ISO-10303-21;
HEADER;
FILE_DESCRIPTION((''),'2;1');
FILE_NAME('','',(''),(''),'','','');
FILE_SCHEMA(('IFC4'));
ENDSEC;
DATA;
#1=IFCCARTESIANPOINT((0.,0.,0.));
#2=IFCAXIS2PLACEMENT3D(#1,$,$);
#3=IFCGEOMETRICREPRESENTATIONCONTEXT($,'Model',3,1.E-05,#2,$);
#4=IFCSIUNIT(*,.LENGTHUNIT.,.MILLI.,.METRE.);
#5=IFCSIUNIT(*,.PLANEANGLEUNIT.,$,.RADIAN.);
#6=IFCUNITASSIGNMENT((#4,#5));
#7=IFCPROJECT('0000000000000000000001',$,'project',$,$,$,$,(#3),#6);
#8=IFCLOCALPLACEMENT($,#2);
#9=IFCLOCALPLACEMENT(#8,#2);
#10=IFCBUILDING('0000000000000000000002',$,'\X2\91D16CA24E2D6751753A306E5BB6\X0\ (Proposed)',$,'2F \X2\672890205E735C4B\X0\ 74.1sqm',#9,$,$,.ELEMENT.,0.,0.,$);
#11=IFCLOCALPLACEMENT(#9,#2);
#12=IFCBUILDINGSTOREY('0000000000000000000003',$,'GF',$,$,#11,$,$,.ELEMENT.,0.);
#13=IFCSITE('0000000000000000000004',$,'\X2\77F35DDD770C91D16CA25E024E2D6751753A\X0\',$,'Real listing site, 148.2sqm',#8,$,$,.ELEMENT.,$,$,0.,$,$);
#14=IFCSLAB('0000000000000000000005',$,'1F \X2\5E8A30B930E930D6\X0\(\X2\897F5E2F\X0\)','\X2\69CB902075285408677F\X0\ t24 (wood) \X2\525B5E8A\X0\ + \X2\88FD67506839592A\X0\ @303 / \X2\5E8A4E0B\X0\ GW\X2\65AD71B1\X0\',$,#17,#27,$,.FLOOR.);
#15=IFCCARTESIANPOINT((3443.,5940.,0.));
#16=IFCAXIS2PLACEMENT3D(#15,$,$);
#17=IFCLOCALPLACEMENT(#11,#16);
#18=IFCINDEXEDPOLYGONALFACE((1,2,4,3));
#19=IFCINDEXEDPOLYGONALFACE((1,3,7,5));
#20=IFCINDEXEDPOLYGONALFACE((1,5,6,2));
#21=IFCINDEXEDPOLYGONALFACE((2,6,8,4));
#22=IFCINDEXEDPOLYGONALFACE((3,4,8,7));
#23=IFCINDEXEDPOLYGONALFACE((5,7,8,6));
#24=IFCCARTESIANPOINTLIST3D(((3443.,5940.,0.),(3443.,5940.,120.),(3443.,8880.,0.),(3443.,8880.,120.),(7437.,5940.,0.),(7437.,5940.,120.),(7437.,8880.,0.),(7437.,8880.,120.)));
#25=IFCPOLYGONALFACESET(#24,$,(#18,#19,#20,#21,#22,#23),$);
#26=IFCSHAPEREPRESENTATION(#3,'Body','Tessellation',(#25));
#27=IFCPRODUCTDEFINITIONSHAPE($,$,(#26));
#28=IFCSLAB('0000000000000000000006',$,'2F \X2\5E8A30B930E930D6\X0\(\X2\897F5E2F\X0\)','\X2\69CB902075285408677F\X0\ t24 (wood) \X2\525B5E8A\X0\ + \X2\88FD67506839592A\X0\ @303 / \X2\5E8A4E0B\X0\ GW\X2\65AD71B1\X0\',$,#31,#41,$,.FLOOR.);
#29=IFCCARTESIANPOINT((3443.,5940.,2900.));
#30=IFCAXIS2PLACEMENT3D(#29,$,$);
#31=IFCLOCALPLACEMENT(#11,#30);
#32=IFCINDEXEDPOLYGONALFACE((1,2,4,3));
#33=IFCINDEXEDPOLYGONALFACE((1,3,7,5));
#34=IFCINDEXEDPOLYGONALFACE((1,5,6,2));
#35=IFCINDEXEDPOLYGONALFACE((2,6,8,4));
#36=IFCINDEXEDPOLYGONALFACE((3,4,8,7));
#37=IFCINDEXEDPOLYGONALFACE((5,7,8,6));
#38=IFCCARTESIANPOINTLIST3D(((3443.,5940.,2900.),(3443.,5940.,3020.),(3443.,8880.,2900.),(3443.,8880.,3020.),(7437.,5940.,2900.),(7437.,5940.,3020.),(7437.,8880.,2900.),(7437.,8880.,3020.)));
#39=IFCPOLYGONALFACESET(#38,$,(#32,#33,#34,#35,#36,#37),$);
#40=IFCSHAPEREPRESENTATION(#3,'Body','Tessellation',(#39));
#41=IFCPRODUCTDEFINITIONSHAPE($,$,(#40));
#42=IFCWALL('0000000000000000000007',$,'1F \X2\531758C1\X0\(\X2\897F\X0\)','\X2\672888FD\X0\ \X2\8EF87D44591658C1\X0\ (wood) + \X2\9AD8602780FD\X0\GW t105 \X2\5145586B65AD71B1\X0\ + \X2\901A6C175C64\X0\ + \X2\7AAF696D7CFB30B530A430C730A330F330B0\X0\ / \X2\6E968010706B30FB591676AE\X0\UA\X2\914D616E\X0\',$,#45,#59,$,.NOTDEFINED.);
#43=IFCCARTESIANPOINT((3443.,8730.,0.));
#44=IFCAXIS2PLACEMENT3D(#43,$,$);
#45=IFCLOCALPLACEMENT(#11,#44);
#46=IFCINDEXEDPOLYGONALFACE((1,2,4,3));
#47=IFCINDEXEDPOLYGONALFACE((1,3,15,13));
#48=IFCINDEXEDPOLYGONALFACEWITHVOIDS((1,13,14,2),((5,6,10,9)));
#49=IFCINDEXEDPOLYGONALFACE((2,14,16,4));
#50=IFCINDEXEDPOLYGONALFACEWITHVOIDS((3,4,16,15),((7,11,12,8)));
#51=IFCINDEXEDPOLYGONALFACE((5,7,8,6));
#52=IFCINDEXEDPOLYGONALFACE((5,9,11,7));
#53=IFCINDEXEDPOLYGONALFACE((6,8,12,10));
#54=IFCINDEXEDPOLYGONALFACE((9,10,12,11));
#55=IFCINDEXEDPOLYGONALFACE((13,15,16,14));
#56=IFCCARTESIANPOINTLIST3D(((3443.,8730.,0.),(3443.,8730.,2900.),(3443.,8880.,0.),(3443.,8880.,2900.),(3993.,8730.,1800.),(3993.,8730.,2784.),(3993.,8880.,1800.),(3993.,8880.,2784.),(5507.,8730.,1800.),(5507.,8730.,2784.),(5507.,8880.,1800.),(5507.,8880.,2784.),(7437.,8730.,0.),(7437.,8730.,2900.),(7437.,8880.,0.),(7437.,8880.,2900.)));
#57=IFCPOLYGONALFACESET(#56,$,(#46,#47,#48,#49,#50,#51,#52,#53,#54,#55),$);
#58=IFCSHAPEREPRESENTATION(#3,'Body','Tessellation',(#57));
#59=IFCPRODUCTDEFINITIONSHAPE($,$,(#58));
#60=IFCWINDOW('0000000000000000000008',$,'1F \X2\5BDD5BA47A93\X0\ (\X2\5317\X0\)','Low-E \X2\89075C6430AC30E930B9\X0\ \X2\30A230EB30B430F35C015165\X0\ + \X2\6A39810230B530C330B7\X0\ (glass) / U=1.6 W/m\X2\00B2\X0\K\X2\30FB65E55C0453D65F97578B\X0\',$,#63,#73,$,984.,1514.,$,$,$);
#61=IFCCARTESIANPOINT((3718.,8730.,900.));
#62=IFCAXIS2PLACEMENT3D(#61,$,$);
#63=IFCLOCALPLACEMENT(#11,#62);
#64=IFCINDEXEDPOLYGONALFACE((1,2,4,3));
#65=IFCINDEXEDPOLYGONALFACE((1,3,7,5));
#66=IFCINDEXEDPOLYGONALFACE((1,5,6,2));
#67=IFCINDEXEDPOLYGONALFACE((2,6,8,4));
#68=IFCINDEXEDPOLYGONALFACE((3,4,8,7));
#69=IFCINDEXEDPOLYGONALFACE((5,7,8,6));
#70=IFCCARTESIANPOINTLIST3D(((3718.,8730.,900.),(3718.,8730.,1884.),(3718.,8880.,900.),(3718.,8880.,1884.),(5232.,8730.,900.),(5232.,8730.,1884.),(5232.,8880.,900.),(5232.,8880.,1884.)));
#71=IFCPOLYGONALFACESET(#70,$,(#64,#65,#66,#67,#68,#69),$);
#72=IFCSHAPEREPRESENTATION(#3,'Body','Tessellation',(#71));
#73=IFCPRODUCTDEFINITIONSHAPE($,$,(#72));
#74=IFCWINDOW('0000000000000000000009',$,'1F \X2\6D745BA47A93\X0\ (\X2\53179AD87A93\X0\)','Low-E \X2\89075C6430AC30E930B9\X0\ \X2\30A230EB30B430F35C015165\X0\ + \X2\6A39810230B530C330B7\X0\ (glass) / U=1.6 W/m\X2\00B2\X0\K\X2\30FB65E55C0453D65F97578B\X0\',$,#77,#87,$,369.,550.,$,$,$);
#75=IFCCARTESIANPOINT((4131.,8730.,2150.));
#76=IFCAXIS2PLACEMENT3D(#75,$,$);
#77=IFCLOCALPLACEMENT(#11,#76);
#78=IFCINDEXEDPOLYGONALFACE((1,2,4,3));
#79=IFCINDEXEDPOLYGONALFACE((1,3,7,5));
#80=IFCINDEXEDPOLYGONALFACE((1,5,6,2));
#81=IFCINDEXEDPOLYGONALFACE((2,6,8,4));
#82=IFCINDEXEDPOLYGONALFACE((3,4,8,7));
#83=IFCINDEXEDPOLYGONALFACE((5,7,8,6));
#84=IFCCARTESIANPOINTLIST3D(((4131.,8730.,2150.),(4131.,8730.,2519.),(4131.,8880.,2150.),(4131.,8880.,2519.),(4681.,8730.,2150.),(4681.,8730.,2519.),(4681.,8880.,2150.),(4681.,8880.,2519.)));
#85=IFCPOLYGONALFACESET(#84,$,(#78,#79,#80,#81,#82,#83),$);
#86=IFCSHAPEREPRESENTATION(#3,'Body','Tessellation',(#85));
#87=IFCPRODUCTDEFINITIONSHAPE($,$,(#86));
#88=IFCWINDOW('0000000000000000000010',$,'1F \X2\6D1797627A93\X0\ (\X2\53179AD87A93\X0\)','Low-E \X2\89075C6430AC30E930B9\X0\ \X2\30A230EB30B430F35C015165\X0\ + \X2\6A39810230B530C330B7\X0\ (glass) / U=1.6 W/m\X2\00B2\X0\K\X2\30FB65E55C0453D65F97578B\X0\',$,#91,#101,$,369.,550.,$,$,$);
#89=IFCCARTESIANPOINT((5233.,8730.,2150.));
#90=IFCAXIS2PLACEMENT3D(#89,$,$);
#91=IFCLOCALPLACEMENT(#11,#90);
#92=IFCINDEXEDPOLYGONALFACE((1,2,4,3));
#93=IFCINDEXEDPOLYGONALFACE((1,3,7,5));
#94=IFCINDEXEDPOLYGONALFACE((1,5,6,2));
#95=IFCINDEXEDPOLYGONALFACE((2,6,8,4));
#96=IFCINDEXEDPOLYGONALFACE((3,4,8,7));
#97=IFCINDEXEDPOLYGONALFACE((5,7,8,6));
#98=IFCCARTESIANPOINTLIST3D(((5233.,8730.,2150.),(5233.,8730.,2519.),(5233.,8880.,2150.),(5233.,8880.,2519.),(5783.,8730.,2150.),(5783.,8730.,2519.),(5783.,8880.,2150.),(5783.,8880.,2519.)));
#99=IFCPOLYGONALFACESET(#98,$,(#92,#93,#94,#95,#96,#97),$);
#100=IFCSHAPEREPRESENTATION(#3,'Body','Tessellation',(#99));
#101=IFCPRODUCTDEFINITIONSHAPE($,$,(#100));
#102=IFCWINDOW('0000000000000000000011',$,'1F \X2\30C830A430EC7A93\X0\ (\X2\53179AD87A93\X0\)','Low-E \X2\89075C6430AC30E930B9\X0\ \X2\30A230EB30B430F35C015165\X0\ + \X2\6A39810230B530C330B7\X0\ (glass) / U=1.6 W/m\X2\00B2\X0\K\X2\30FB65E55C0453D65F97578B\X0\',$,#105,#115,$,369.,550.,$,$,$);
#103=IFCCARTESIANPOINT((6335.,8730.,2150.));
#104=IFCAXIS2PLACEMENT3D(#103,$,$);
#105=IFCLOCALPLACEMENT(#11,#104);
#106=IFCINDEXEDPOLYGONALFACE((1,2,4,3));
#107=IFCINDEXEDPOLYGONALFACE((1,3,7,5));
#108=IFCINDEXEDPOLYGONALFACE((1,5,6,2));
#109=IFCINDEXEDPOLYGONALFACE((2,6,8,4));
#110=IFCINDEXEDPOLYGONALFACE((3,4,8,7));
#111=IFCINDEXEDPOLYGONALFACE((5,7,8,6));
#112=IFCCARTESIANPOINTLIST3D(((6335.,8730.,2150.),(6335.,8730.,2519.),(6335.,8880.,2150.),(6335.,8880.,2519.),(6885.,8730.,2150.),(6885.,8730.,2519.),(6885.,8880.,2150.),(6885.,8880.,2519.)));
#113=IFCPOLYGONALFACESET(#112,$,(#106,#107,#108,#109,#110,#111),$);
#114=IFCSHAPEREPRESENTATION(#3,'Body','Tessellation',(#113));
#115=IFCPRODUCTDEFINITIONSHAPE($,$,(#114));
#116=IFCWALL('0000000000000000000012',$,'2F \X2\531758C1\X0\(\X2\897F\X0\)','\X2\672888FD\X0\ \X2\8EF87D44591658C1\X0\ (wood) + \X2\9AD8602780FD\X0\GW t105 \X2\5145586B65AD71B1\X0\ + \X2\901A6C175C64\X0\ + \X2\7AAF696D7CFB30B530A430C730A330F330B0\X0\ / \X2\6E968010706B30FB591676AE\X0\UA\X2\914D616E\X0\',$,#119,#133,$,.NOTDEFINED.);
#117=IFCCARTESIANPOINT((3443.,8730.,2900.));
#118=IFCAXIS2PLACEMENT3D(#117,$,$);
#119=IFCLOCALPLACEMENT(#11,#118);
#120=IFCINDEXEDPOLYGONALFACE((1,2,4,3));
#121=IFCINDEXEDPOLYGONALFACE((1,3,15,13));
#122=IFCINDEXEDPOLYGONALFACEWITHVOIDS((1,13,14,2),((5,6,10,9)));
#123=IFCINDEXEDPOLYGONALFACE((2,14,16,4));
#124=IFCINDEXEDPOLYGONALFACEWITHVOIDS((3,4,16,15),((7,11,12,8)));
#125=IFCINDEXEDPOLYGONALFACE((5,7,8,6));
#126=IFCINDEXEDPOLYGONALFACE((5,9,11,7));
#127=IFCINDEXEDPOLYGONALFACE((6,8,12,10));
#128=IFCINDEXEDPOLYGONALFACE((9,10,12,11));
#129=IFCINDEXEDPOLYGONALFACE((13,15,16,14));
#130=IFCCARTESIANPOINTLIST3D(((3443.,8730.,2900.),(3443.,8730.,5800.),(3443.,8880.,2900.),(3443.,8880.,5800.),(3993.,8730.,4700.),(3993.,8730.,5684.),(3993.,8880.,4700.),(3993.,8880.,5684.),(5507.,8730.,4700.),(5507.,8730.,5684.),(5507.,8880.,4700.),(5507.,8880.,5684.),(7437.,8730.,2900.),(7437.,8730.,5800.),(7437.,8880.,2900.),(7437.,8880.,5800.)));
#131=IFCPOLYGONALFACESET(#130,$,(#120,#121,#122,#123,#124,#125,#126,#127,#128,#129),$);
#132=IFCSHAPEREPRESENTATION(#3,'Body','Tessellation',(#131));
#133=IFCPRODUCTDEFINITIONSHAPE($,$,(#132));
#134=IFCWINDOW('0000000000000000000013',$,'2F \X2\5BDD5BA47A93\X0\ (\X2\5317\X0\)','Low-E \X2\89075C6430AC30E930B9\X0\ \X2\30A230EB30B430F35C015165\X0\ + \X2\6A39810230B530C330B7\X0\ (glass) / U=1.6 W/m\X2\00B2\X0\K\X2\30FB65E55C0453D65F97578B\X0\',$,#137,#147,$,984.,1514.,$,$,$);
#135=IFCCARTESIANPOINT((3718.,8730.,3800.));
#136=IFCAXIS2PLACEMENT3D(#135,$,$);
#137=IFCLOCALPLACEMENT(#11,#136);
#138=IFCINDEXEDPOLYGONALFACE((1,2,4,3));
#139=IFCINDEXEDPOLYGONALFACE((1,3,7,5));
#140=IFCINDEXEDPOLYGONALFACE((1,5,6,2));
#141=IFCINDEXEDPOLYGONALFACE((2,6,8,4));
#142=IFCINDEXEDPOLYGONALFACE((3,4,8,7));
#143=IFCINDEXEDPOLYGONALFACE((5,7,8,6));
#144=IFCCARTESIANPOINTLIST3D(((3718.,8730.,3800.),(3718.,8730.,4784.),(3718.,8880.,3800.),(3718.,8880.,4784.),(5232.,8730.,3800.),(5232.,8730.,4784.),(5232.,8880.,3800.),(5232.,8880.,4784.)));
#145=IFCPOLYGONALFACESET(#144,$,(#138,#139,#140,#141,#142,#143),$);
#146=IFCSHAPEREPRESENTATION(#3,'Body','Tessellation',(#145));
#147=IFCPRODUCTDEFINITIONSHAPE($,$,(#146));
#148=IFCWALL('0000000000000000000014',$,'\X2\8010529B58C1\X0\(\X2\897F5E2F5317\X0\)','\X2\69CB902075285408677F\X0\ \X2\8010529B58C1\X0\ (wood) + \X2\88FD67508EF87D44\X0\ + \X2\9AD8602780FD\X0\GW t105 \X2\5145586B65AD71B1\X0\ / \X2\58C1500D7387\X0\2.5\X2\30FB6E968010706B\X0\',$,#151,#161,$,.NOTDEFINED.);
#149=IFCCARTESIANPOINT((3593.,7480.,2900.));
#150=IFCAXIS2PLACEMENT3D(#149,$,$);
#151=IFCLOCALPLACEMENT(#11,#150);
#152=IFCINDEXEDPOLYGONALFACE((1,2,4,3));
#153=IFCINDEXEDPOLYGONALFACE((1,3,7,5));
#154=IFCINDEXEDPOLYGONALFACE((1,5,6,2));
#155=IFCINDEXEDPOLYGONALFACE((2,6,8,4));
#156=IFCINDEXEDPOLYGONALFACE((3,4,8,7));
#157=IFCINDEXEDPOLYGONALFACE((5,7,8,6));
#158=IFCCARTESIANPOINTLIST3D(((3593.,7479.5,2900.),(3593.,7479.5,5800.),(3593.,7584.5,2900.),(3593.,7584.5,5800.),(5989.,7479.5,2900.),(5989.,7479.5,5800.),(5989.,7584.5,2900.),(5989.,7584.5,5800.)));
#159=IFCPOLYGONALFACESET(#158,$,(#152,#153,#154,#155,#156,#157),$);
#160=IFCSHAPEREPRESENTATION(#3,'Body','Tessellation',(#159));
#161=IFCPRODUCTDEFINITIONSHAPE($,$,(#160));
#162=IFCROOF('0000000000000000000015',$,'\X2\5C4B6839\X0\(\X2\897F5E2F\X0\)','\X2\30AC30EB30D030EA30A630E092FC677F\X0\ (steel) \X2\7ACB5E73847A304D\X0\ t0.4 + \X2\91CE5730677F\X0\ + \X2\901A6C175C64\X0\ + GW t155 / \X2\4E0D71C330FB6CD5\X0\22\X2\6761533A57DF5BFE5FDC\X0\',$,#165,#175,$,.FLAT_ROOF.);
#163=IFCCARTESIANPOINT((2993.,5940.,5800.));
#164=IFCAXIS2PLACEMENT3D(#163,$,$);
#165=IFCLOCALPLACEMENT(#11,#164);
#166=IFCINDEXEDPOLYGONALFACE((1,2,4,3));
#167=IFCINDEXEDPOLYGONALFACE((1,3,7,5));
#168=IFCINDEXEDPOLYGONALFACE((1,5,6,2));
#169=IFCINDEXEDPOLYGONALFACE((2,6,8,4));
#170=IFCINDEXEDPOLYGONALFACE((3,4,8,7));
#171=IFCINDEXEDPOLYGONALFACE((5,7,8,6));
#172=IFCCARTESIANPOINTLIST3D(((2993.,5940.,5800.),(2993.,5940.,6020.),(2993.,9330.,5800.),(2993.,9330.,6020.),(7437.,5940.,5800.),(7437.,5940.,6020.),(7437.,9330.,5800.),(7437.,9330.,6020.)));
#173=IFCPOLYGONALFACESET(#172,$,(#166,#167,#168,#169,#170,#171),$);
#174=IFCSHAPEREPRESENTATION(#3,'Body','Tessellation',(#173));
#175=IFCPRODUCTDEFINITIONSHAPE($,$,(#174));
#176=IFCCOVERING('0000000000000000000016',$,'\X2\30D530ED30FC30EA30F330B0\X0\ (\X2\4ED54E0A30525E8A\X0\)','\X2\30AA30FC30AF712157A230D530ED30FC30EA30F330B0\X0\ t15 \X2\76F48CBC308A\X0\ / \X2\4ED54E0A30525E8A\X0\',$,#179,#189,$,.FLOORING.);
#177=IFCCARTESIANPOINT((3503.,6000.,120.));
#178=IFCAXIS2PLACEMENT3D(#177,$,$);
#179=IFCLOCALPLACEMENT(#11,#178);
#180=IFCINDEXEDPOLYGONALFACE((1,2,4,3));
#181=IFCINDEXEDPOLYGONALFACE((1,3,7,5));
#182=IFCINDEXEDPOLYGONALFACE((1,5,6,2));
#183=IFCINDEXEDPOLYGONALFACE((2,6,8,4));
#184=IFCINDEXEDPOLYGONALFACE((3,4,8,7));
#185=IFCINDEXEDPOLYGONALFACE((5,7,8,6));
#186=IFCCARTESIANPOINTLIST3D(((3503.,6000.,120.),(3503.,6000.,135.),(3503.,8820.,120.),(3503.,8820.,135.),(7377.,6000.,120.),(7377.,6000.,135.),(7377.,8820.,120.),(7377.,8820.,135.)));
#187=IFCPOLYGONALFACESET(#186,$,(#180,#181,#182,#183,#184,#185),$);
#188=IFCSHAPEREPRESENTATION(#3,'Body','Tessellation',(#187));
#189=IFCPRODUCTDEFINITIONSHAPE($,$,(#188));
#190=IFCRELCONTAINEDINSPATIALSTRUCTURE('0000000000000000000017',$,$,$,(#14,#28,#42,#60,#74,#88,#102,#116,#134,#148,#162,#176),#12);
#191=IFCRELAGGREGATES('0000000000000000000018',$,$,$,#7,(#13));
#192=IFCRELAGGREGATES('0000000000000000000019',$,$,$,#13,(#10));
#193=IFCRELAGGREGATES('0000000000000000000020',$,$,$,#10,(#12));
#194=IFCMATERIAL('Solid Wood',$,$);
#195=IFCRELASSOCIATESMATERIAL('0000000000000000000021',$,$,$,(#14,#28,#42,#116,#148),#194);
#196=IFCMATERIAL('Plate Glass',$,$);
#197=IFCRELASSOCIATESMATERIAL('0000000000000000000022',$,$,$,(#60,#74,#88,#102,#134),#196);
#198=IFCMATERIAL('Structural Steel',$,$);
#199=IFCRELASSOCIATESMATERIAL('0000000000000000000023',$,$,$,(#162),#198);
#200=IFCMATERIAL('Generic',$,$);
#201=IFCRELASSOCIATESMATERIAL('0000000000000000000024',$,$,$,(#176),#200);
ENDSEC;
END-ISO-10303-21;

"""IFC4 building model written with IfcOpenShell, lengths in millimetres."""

from ifc_helpers import new_model, si_unit, frame, frame_2d, origin, place, context, project, spatial, rectangle, extrude, material, element, fill, save


model = new_model("IFC4")

# Units and contexts
model_context = context("Model", 3, precision=1e-05, world=origin())
ifc_project = project(units=[si_unit("LENGTHUNIT", "METRE", prefix="MILLI"), si_unit("PLANEANGLEUNIT", "RADIAN")], contexts=[model_context])

# Site, building, storey
site_placement = place(None, origin())
site = spatial("IfcSite", under=ifc_project, at=site_placement, Name="石川県金沢市中村町", ObjectType="Real listing site, 148.2sqm", CompositionType="ELEMENT", RefElevation=0.0)
building_placement = place(site_placement, origin())
building = spatial("IfcBuilding", under=site, at=building_placement, Name="金沢中村町の家 (Proposed)", ObjectType="2F 木造平屋 74.1sqm", CompositionType="ELEMENT", ElevationOfRefHeight=0.0, ElevationOfTerrain=0.0)
storey_placement = place(building_placement, origin())
storey = spatial("IfcBuildingStorey", under=building, at=storey_placement, Name="GF", CompositionType="ELEMENT", Elevation=0.0)

# Slabs
ifc_material_1 = material(Name="Solid Wood")
slab_1_placement = place(storey_placement, frame((3443.0, 5940.0, 0.0)))
element("IfcSlab", 1, at=slab_1_placement, inside=storey, material=ifc_material_1, Name="1F 床スラブ(西帯)", Description="構造用合板 t24 (wood) 剛床 + 製材根太 @303 / 床下 GW断熱", PredefinedType="FLOOR", context=model_context, shape_type="SweptSolid", body=[
    extrude(rectangle(XDim=3994.0, YDim=2940.0, at=frame_2d((1997.0, 1470.0))), frame((3443.0, 5940.0, 0.0)), (0.0, 0.0, 1.0), 120.0),
])
slab_2_placement = place(storey_placement, frame((3443.0, 5940.0, 2900.0)))
element("IfcSlab", 2, at=slab_2_placement, inside=storey, material=ifc_material_1, Name="2F 床スラブ(西帯)", Description="構造用合板 t24 (wood) 剛床 + 製材根太 @303 / 床下 GW断熱", PredefinedType="FLOOR", context=model_context, shape_type="SweptSolid", body=[
    extrude(rectangle(XDim=3994.0, YDim=2940.0, at=frame_2d((1997.0, 1470.0))), frame((3443.0, 5940.0, 2900.0)), (0.0, 0.0, 1.0), 120.0),
])

# Wall, openings, windows
wall_1_placement = place(storey_placement, frame((3443.0, 8730.0, 0.0)))
wall_1 = element("IfcWall", 3, at=wall_1_placement, inside=storey, material=ifc_material_1, Name="1F 北壁(西)", Description="木製 軸組外壁 (wood) + 高性能GW t105 充填断熱 + 通気層 + 窯業系サイディング / 準耐火・外皮UA配慮", PredefinedType="NOTDEFINED", context=model_context, shape_type="SweptSolid", body=[
    extrude(rectangle(XDim=3994.0, YDim=150.0, at=frame_2d((1997.0, 75.0))), frame((3443.0, 8730.0, 0.0)), (0.0, 0.0, 1.0), 2900.0),
])
opening_1_placement = place(storey_placement, frame((3718.0, 8730.0, 900.0)))
opening_1 = element("IfcOpeningElement", 4, at=opening_1_placement, cuts=wall_1, PredefinedType="NOTDEFINED", context=model_context, shape_type="SweptSolid", body=[
    extrude(rectangle(XDim=1514.0, YDim=150.0, at=frame_2d((757.0, 75.0))), frame((3718.0, 8730.0, 900.0)), (0.0, 0.0, 1.0), 984.0),
])
opening_2_placement = place(storey_placement, frame((4131.0, 8730.0, 2150.0)))
opening_2 = element("IfcOpeningElement", 5, at=opening_2_placement, cuts=wall_1, PredefinedType="NOTDEFINED", context=model_context, shape_type="SweptSolid", body=[
    extrude(rectangle(XDim=550.0, YDim=150.0, at=frame_2d((275.0, 75.0))), frame((4131.0, 8730.0, 2150.0)), (0.0, 0.0, 1.0), 369.0),
])
opening_3_placement = place(storey_placement, frame((5233.0, 8730.0, 2150.0)))
opening_3 = element("IfcOpeningElement", 6, at=opening_3_placement, cuts=wall_1, PredefinedType="NOTDEFINED", context=model_context, shape_type="SweptSolid", body=[
    extrude(rectangle(XDim=550.0, YDim=150.0, at=frame_2d((275.0, 75.0))), frame((5233.0, 8730.0, 2150.0)), (0.0, 0.0, 1.0), 369.0),
])
opening_4_placement = place(storey_placement, frame((6335.0, 8730.0, 2150.0)))
opening_4 = element("IfcOpeningElement", 7, at=opening_4_placement, cuts=wall_1, PredefinedType="NOTDEFINED", context=model_context, shape_type="SweptSolid", body=[
    extrude(rectangle(XDim=550.0, YDim=150.0, at=frame_2d((275.0, 75.0))), frame((6335.0, 8730.0, 2150.0)), (0.0, 0.0, 1.0), 369.0),
])
ifc_material_2 = material(Name="Plate Glass")
window_1_placement = place(storey_placement, frame((3718.0, 8730.0, 900.0)))
window_1 = element("IfcWindow", 8, at=window_1_placement, inside=storey, material=ifc_material_2, Name="1F 寝室窓 (北)", Description="Low-E 複層ガラス アルゴン封入 + 樹脂サッシ (glass) / U=1.6 W/m²K・日射取得型", OverallHeight=984.0, OverallWidth=1514.0, context=model_context, shape_type="SweptSolid", body=[
    extrude(rectangle(XDim=1514.0, YDim=150.0, at=frame_2d((757.0, 75.0))), frame((3718.0, 8730.0, 900.0)), (0.0, 0.0, 1.0), 984.0),
])
fill(opening_1, window_1)
window_2_placement = place(storey_placement, frame((4131.0, 8730.0, 2150.0)))
window_2 = element("IfcWindow", 9, at=window_2_placement, inside=storey, material=ifc_material_2, Name="1F 浴室窓 (北高窓)", Description="Low-E 複層ガラス アルゴン封入 + 樹脂サッシ (glass) / U=1.6 W/m²K・日射取得型", OverallHeight=369.0, OverallWidth=550.0, context=model_context, shape_type="SweptSolid", body=[
    extrude(rectangle(XDim=550.0, YDim=150.0, at=frame_2d((275.0, 75.0))), frame((4131.0, 8730.0, 2150.0)), (0.0, 0.0, 1.0), 369.0),
])
fill(opening_2, window_2)
window_3_placement = place(storey_placement, frame((5233.0, 8730.0, 2150.0)))
window_3 = element("IfcWindow", 10, at=window_3_placement, inside=storey, material=ifc_material_2, Name="1F 洗面窓 (北高窓)", Description="Low-E 複層ガラス アルゴン封入 + 樹脂サッシ (glass) / U=1.6 W/m²K・日射取得型", OverallHeight=369.0, OverallWidth=550.0, context=model_context, shape_type="SweptSolid", body=[
    extrude(rectangle(XDim=550.0, YDim=150.0, at=frame_2d((275.0, 75.0))), frame((5233.0, 8730.0, 2150.0)), (0.0, 0.0, 1.0), 369.0),
])
fill(opening_3, window_3)
window_4_placement = place(storey_placement, frame((6335.0, 8730.0, 2150.0)))
window_4 = element("IfcWindow", 11, at=window_4_placement, inside=storey, material=ifc_material_2, Name="1F トイレ窓 (北高窓)", Description="Low-E 複層ガラス アルゴン封入 + 樹脂サッシ (glass) / U=1.6 W/m²K・日射取得型", OverallHeight=369.0, OverallWidth=550.0, context=model_context, shape_type="SweptSolid", body=[
    extrude(rectangle(XDim=550.0, YDim=150.0, at=frame_2d((275.0, 75.0))), frame((6335.0, 8730.0, 2150.0)), (0.0, 0.0, 1.0), 369.0),
])
fill(opening_4, window_4)

# Wall, opening, window
wall_2_placement = place(storey_placement, frame((3443.0, 8730.0, 2900.0)))
wall_2 = element("IfcWall", 12, at=wall_2_placement, inside=storey, material=ifc_material_1, Name="2F 北壁(西)", Description="木製 軸組外壁 (wood) + 高性能GW t105 充填断熱 + 通気層 + 窯業系サイディング / 準耐火・外皮UA配慮", PredefinedType="NOTDEFINED", context=model_context, shape_type="SweptSolid", body=[
    extrude(rectangle(XDim=3994.0, YDim=150.0, at=frame_2d((1997.0, 75.0))), frame((3443.0, 8730.0, 2900.0)), (0.0, 0.0, 1.0), 2900.0),
])
opening_5_placement = place(storey_placement, frame((3718.0, 8730.0, 3800.0)))
opening_5 = element("IfcOpeningElement", 13, at=opening_5_placement, cuts=wall_2, PredefinedType="NOTDEFINED", context=model_context, shape_type="SweptSolid", body=[
    extrude(rectangle(XDim=1514.0, YDim=150.0, at=frame_2d((757.0, 75.0))), frame((3718.0, 8730.0, 3800.0)), (0.0, 0.0, 1.0), 984.0),
])
window_5_placement = place(storey_placement, frame((3718.0, 8730.0, 3800.0)))
window_5 = element("IfcWindow", 14, at=window_5_placement, inside=storey, material=ifc_material_2, Name="2F 寝室窓 (北)", Description="Low-E 複層ガラス アルゴン封入 + 樹脂サッシ (glass) / U=1.6 W/m²K・日射取得型", OverallHeight=984.0, OverallWidth=1514.0, context=model_context, shape_type="SweptSolid", body=[
    extrude(rectangle(XDim=1514.0, YDim=150.0, at=frame_2d((757.0, 75.0))), frame((3718.0, 8730.0, 3800.0)), (0.0, 0.0, 1.0), 984.0),
])
fill(opening_5, window_5)

# Wall
wall_3_placement = place(storey_placement, frame((3593.0, 7480.0, 2900.0)))
element("IfcWall", 15, at=wall_3_placement, inside=storey, material=ifc_material_1, Name="耐力壁(西帯北)", Description="構造用合板 耐力壁 (wood) + 製材軸組 + 高性能GW t105 充填断熱 / 壁倍率2.5・準耐火", PredefinedType="NOTDEFINED", context=model_context, shape_type="SweptSolid", body=[
    extrude(rectangle(XDim=2396.0, YDim=105.0, at=frame_2d((1198.0, 52.0))), frame((3593.0, 7480.0, 2900.0)), (0.0, 0.0, 1.0), 2900.0),
])

# Roof
ifc_material_3 = material(Name="Structural Steel")
for number, where, name in (
    (16, (2993.0, 5940.0, 5800.0), "屋根(西帯)"),
):
    element("IfcRoof", number, at=place(storey_placement, frame(where)), inside=storey, material=ifc_material_3, Name=name, Description="ガルバリウム鋼板 (steel) 立平葺き t0.4 + 野地板 + 通気層 + GW t155 / 不燃・法22条区域対応", PredefinedType="FLAT_ROOF", context=model_context, shape_type="SweptSolid", body=[
        extrude(rectangle(XDim=4444.0, YDim=3390.0, at=frame_2d((2222.0, 1695.0))), frame((2993.0, 5940.0, 5800.0)), (0.0, 0.0, 1.0), 220.0),
    ])

# Covering
ifc_material_4 = material(Name="Generic")
covering_1_placement = place(storey_placement, frame((3503.0, 6000.0, 120.0)))
element("IfcCovering", 17, at=covering_1_placement, inside=storey, material=ifc_material_4, Name="フローリング (仕上げ床)", Description="オーク無垢フローリング t15 直貼り / 仕上げ床", PredefinedType="FLOORING", context=model_context, shape_type="SweptSolid", body=[
    extrude(rectangle(XDim=3874.0, YDim=2820.0, at=frame_2d((1937.0, 1410.0))), frame((3503.0, 6000.0, 120.0)), (0.0, 0.0, 1.0), 15.0),
])

save(model, "model.ifc")
